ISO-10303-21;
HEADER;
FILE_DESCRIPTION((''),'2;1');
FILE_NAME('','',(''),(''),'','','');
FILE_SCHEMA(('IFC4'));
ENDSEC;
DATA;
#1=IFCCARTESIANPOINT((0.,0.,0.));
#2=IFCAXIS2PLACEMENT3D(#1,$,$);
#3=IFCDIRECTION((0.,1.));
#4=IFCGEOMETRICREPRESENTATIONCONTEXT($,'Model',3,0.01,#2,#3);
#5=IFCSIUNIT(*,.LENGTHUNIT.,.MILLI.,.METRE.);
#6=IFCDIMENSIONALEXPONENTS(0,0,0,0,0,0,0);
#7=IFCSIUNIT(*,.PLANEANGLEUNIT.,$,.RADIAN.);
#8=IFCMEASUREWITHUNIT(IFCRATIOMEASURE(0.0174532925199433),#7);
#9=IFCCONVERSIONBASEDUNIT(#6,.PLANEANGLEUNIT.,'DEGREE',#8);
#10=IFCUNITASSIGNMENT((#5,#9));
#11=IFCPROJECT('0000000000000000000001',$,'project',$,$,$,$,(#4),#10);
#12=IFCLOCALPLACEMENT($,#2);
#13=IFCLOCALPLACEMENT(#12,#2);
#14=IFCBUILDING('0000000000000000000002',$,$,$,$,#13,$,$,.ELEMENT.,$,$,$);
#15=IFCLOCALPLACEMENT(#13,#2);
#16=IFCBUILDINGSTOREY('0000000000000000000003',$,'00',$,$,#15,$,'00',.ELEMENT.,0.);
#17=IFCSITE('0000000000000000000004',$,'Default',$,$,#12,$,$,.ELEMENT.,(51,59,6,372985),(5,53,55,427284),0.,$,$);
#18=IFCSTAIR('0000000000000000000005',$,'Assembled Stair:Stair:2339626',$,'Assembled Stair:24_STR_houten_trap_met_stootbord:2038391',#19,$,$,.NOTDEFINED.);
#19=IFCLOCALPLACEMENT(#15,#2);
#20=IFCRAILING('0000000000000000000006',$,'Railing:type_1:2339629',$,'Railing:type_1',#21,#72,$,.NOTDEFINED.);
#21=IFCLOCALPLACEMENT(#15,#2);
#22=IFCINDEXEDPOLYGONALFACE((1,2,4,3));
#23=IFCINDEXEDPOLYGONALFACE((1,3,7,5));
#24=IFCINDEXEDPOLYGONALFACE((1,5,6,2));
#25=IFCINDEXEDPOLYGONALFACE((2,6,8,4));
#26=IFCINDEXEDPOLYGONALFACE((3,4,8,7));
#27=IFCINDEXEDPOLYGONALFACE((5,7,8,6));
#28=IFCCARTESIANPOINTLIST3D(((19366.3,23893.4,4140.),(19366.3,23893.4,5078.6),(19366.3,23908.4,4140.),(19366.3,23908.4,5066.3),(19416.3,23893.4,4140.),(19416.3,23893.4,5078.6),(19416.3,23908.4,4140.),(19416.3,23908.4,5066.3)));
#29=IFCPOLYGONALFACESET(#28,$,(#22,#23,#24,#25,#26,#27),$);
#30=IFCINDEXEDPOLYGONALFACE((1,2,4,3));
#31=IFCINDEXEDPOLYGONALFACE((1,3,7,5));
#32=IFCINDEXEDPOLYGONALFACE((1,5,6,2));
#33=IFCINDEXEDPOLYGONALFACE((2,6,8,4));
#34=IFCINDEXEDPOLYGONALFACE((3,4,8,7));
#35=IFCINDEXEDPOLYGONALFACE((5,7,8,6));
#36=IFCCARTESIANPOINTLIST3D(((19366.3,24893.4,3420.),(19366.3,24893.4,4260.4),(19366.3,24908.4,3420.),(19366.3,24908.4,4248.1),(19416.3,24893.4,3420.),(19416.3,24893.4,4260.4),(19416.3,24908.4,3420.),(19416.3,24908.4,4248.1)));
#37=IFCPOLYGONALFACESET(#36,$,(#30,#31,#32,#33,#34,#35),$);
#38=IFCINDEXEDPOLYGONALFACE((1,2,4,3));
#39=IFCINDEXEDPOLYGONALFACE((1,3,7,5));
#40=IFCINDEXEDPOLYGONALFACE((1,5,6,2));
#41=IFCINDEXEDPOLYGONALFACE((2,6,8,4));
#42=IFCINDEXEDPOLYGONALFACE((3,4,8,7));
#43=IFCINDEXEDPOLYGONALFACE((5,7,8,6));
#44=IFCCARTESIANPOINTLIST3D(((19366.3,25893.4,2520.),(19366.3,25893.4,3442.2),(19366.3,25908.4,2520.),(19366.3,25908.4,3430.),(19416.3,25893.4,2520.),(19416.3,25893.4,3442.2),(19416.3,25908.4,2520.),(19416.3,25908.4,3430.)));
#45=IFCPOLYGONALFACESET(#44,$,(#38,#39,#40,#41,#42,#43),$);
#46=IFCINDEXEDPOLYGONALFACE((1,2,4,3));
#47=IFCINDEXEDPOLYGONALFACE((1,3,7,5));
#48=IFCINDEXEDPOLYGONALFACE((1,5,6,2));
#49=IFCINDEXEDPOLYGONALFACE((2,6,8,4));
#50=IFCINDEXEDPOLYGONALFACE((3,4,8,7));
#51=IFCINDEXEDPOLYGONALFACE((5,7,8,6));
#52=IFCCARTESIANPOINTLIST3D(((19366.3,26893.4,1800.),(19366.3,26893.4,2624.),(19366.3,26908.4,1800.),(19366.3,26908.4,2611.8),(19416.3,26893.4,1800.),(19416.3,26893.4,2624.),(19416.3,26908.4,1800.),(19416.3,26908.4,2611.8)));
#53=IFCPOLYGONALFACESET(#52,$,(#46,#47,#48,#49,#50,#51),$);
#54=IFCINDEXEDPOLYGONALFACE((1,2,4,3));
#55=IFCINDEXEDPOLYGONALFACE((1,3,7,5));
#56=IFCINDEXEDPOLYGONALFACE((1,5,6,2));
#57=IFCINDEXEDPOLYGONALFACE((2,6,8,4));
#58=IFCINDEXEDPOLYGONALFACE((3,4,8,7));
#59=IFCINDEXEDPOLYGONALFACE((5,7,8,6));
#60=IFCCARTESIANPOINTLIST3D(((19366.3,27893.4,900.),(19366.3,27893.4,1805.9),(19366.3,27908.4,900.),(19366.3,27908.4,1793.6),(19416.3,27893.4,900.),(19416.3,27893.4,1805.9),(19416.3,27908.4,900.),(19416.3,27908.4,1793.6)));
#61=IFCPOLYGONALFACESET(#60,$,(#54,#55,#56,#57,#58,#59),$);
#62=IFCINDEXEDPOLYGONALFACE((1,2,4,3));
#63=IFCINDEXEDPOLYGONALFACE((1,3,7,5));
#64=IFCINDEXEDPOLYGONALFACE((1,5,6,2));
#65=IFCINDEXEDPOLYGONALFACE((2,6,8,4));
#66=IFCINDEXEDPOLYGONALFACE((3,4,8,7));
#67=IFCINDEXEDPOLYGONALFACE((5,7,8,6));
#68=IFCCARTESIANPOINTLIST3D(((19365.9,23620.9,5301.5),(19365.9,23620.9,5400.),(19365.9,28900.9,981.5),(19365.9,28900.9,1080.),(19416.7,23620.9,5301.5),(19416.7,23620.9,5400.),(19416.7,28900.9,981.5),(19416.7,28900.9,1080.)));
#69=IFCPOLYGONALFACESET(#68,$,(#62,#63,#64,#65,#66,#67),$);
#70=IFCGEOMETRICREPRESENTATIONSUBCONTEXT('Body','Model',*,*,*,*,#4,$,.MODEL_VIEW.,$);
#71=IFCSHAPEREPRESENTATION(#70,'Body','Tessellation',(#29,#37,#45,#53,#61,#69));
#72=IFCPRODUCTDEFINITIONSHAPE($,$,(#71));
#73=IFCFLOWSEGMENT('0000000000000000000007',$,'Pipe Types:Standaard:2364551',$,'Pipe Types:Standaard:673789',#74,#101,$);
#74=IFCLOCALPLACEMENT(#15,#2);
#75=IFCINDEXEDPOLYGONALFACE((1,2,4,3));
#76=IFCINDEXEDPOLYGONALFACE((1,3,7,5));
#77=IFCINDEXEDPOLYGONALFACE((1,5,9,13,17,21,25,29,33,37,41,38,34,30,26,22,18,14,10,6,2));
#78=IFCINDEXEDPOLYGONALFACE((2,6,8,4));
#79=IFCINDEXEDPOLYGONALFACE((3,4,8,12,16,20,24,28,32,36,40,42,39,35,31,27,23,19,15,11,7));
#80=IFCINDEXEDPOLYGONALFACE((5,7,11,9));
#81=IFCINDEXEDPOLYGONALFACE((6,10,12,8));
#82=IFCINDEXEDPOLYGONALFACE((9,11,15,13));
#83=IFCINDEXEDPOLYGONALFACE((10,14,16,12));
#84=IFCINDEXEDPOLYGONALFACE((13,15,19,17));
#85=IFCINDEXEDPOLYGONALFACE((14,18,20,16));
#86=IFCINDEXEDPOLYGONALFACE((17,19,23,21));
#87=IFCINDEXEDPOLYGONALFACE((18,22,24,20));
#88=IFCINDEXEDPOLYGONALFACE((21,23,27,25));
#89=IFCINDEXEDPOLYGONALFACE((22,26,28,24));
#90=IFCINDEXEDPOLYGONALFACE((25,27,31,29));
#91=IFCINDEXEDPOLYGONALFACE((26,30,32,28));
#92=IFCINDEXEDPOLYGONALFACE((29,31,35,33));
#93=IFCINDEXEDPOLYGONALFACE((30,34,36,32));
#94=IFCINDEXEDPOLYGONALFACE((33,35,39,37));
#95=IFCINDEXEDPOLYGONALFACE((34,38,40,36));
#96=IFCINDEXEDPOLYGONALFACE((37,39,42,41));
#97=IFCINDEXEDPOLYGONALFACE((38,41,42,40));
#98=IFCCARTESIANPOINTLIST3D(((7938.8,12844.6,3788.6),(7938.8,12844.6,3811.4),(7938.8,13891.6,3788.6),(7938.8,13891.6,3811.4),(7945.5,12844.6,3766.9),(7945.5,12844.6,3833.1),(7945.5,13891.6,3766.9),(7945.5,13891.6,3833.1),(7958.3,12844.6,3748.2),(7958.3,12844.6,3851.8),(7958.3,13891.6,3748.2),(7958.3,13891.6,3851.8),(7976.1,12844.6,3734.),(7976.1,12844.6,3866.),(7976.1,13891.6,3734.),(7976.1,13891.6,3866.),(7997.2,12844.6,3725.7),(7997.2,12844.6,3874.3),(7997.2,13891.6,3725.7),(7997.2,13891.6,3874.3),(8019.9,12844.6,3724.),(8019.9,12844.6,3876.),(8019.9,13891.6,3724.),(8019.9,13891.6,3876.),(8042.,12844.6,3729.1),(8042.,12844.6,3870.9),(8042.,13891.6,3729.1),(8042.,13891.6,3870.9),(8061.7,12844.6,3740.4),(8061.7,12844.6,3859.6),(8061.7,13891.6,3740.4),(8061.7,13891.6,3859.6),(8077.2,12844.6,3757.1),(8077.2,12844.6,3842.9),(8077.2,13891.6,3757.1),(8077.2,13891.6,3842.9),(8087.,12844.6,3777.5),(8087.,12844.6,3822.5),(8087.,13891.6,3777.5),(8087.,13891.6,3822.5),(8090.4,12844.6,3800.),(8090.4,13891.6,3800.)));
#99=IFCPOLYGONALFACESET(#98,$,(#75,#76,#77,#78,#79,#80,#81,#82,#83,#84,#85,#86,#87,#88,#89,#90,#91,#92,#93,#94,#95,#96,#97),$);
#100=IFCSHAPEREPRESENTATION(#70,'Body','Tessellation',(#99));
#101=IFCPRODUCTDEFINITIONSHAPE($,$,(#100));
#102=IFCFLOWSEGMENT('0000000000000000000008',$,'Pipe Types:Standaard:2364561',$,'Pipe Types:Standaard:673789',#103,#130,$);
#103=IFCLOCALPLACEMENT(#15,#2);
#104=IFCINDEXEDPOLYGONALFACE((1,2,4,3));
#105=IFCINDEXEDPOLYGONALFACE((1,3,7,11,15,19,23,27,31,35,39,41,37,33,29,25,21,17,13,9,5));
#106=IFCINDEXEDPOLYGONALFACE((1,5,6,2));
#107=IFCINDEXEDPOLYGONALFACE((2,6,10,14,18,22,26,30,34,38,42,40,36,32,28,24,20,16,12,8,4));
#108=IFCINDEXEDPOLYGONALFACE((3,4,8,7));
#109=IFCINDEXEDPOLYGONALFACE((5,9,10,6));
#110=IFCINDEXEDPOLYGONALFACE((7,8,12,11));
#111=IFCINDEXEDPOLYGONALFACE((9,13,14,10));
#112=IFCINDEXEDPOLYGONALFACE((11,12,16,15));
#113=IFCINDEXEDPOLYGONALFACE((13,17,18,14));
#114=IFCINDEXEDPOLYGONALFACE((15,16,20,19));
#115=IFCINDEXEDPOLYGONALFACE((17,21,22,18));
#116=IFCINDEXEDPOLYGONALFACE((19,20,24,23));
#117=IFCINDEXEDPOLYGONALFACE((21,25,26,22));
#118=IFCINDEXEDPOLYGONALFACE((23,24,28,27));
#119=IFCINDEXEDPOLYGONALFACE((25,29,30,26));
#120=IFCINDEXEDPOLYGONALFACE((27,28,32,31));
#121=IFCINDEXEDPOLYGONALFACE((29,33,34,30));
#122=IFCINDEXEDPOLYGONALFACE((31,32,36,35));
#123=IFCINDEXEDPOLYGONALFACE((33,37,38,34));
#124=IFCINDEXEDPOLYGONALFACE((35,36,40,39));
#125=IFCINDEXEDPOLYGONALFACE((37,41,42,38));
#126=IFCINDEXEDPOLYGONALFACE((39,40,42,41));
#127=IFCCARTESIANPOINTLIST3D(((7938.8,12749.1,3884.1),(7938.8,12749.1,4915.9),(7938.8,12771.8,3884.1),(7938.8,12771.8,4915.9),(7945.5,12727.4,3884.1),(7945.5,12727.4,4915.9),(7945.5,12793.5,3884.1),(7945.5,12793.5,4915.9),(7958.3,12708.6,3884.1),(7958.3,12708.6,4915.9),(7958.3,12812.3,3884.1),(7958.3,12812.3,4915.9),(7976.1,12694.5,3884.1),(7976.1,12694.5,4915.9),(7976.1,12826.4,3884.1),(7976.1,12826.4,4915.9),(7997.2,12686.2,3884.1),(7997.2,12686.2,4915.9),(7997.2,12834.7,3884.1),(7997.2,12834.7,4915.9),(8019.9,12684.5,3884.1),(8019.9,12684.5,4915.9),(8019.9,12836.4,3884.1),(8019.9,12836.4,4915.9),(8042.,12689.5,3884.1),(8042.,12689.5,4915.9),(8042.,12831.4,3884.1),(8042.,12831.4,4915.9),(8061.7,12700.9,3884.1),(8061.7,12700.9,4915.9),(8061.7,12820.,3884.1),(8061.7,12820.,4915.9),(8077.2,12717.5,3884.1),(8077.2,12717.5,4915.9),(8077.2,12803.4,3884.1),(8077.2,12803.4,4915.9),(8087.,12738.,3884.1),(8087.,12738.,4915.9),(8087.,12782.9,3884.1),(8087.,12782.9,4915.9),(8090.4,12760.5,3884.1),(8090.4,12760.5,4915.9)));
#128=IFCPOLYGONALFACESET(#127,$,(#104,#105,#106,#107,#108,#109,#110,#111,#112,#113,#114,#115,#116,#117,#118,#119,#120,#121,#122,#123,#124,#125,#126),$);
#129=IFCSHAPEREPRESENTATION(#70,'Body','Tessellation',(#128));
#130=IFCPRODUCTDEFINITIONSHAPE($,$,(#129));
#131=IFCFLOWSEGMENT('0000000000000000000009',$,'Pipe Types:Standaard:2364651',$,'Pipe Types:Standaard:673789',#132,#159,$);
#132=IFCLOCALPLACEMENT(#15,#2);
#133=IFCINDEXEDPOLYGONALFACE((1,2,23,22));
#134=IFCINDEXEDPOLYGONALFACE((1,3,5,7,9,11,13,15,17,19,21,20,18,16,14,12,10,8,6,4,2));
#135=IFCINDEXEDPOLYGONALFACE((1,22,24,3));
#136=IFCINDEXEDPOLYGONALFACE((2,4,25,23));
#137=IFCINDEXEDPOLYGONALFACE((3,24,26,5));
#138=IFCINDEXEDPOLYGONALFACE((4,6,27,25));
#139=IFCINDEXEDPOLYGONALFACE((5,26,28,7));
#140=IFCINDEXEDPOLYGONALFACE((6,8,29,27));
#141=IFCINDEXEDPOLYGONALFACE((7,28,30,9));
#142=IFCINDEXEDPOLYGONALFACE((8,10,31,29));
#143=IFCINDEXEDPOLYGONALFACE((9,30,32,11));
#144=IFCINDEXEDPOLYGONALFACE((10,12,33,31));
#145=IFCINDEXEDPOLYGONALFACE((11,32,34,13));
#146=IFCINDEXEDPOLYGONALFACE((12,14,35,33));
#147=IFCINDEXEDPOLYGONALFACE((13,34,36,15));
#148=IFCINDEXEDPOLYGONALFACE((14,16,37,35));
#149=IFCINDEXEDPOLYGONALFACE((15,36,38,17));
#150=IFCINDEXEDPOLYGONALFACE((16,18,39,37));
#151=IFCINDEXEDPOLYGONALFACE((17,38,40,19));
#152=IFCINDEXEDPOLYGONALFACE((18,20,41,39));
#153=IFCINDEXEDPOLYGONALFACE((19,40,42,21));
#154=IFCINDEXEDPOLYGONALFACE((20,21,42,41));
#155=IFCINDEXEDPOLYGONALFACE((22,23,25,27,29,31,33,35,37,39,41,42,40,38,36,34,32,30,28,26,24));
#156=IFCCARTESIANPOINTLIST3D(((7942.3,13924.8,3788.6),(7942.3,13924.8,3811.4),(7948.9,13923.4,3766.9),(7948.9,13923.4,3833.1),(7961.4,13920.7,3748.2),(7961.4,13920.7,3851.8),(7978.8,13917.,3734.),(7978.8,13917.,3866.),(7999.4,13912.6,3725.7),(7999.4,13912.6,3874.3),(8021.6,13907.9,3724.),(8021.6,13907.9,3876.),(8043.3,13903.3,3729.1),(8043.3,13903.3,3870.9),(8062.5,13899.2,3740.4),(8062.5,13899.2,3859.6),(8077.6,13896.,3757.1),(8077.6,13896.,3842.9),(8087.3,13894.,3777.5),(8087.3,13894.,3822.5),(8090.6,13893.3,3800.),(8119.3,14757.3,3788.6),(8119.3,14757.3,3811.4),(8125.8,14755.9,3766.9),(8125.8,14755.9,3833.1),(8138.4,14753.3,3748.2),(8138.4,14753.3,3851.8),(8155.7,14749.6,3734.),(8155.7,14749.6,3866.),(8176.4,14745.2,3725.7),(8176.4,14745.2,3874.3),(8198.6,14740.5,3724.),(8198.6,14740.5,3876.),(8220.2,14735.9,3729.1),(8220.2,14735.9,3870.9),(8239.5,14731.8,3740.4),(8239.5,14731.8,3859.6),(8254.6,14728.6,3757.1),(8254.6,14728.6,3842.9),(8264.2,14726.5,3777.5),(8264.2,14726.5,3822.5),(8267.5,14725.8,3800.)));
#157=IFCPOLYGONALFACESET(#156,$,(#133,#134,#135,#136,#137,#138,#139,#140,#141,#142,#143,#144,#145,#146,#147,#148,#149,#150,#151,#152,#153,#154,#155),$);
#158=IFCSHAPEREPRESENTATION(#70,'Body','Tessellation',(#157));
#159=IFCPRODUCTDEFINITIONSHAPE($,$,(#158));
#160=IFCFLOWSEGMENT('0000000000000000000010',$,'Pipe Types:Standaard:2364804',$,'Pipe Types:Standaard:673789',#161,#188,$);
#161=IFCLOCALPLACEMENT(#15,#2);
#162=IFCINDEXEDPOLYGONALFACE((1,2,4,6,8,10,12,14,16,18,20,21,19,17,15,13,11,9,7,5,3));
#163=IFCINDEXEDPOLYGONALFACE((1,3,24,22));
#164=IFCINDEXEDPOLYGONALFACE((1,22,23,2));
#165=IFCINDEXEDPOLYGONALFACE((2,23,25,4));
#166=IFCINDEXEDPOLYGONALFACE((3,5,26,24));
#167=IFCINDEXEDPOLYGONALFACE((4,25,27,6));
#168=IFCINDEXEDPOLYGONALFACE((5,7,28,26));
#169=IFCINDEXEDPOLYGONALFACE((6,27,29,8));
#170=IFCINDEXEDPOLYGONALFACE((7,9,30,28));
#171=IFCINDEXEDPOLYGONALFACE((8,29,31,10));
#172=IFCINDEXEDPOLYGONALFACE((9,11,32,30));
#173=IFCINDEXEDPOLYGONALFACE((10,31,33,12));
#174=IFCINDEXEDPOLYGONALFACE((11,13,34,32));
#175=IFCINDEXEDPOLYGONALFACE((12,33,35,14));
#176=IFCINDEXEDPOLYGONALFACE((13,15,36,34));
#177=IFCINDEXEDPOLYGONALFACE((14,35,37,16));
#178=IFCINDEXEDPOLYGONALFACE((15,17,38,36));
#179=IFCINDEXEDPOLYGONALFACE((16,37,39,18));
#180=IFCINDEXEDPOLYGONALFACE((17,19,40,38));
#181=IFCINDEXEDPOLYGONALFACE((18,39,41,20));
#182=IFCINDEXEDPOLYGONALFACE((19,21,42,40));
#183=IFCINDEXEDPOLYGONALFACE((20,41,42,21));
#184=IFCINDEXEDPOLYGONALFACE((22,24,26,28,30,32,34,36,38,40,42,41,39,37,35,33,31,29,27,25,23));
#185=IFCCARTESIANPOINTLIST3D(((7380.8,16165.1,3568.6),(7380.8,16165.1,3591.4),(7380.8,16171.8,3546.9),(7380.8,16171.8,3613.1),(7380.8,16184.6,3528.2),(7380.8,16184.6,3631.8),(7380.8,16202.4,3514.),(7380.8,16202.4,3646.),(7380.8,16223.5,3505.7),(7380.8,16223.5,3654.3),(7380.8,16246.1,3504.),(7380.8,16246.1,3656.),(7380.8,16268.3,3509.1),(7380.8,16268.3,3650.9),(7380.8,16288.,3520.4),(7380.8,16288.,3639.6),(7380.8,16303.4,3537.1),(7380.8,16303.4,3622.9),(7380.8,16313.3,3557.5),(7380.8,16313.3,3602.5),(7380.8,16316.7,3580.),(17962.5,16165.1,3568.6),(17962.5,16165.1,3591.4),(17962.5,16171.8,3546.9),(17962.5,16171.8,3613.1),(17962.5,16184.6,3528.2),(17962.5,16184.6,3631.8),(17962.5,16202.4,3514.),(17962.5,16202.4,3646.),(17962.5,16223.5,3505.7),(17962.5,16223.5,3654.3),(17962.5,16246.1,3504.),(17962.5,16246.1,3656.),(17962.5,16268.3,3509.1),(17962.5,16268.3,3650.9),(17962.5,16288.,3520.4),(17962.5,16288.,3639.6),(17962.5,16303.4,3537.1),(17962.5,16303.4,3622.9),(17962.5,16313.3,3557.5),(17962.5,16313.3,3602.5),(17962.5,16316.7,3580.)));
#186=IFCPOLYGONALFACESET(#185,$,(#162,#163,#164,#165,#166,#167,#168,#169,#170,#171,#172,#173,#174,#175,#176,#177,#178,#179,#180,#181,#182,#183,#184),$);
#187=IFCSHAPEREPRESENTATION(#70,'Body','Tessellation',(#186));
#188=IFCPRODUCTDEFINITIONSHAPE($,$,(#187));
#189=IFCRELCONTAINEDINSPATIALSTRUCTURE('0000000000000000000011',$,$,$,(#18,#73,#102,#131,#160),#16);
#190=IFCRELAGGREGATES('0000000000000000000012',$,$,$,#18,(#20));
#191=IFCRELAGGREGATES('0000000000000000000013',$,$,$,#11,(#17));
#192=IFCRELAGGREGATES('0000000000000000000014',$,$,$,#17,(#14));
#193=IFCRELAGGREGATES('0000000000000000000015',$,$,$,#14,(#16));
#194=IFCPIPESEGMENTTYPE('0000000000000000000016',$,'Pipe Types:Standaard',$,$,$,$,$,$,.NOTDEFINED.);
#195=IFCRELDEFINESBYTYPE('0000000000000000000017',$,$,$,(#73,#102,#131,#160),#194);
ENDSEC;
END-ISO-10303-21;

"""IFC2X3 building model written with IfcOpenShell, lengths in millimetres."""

from ifc_helpers import new_model, entity, si_unit, converted_unit, direction, frame, frame_2d, origin, origin_2d_with_axis, place, context, subcontext, project, spatial, polyline, circle, outline, extrude, type_object, element, aggregate, save


model = new_model("IFC2X3")

# Units and contexts
model_context = context("Model", 3, precision=0.01, world=origin(), true_north=direction((0.0, 1.0)))
body_context = subcontext(model_context, "Body", "Model", "MODEL_VIEW")
ifc_project = project(units=[si_unit("LENGTHUNIT", "METRE", prefix="MILLI"), converted_unit("PLANEANGLEUNIT", "DEGREE", entity("IfcRatioMeasure", 0.0174532925199433), si_unit("PLANEANGLEUNIT", "RADIAN"), dimensions=[0, 0, 0, 0, 0, 0, 0])], contexts=[model_context])

# Site, building, storey
site_placement = place(None, origin())
site = spatial("IfcSite", under=ifc_project, at=site_placement, Name="Default", CompositionType="ELEMENT", RefLatitude=(51, 59, 6, 372985), RefLongitude=(5, 53, 55, 427284), RefElevation=0.0)
building_placement = place(site_placement, origin())
building = spatial("IfcBuilding", under=site, at=building_placement, CompositionType="ELEMENT")
storey_placement = place(building_placement, origin())
storey = spatial("IfcBuildingStorey", under=building, at=storey_placement, Name="00", LongName="00", CompositionType="ELEMENT", Elevation=0.0)

# Stair, railing
stair_1_placement = place(storey_placement, origin())
stair_1 = element("IfcStair", 1, at=stair_1_placement, inside=storey, Name="Assembled Stair:Stair:2339626", ObjectType="Assembled Stair:24_STR_houten_trap_met_stootbord:2038391", ShapeType="NOTDEFINED")
railing_1_placement = place(stair_1_placement, origin())
railing_1 = element("IfcRailing", 2, at=railing_1_placement, Name="Railing:type_1:2339629", ObjectType="Railing:type_1", PredefinedType="NOTDEFINED", context=body_context, shape_type="SweptSolid", body=[
    extrude(outline(polyline([(-466.2, -7.5), (460.1, -7.5), (472.4, 7.5), (-466.2, 7.5), (-466.2, -7.5)])), frame((19366.3, 23900.9, 4606.2), z_axis=(1.0, 0.0, 0.0), x_axis=(0.0, 0.0, 1.0)), (0.0, 0.0, 1.0), 50.0),
    extrude(outline(polyline([(-417.1, -7.5), (411.0, -7.5), (423.3, 7.5), (-417.1, 7.5), (-417.1, -7.5)])), frame((19366.3, 24900.9, 3837.1), z_axis=(1.0, 0.0, 0.0), x_axis=(0.0, 0.0, 1.0)), (0.0, 0.0, 1.0), 50.0),
    extrude(outline(polyline([(-458.0, -7.5), (451.9, -7.5), (464.2, 7.5), (-458.0, 7.5), (-458.0, -7.5)])), frame((19366.3, 25900.9, 2978.0), z_axis=(1.0, 0.0, 0.0), x_axis=(0.0, 0.0, 1.0)), (0.0, 0.0, 1.0), 50.0),
    extrude(outline(polyline([(-409.0, -7.5), (402.8, -7.5), (415.1, 7.5), (-409.0, 7.5), (-409.0, -7.5)])), frame((19366.3, 26900.9, 2209.0), z_axis=(1.0, 0.0, 0.0), x_axis=(0.0, 0.0, 1.0)), (0.0, 0.0, 1.0), 50.0),
    extrude(outline(polyline([(-449.9, -7.5), (443.7, -7.5), (456.0, 7.5), (-449.9, 7.5), (-449.9, -7.5)])), frame((19366.3, 27900.9, 1349.9), z_axis=(1.0, 0.0, 0.0), x_axis=(0.0, 0.0, 1.0)), (0.0, 0.0, 1.0), 50.0),
    extrude(outline(polyline([(-3379.9, -38.1), (3442.2, -38.1), (3379.9, 38.1), (-3442.2, 38.1), (-3379.9, -38.1)])), frame((19365.9, 26260.9, 3190.8), z_axis=(1.0, 0.0, 0.0), x_axis=(0.0, -0.773957, 0.633238)), (0.0, 0.0, 1.0), 50.8),
])
aggregate(stair_1, [railing_1])

# Flow segments
pipe_segment_type = type_object("IfcPipeSegmentType", Name="Pipe Types:Standaard", PredefinedType="NOTDEFINED")
flow_segment_1_placement = place(storey_placement, origin())
element("IfcFlowSegment", 3, at=flow_segment_1_placement, inside=storey, type_object=pipe_segment_type, Name="Pipe Types:Standaard:2364551", ObjectType="Pipe Types:Standaard:673789", context=body_context, shape_type="SweptSolid", body=[
    extrude(circle(Radius=76.2, at=origin_2d_with_axis()), frame((8014.2, 12844.6, 3800.0), z_axis=(0.0, 1.0, 0.0), x_axis=(1.0, 0.0, 0.0)), (0.0, 0.0, 1.0), 1047.0),
])
flow_segment_2_placement = place(storey_placement, origin())
element("IfcFlowSegment", 4, at=flow_segment_2_placement, inside=storey, type_object=pipe_segment_type, Name="Pipe Types:Standaard:2364561", ObjectType="Pipe Types:Standaard:673789", context=body_context, shape_type="SweptSolid", body=[
    extrude(circle(Radius=76.2, at=origin_2d_with_axis()), frame((8014.2, 12760.5, 3884.1)), (0.0, 0.0, 1.0), 1031.7),
])
flow_segment_3_placement = place(storey_placement, origin())
element("IfcFlowSegment", 5, at=flow_segment_3_placement, inside=storey, type_object=pipe_segment_type, Name="Pipe Types:Standaard:2364651", ObjectType="Pipe Types:Standaard:673789", context=body_context, shape_type="SweptSolid", body=[
    extrude(circle(Radius=76.2, at=origin_2d_with_axis()), frame((8016.0, 13909.1, 3800.0), z_axis=(0.207912, 0.978148, 0.0), x_axis=(0.978148, -0.207912, 0.0)), (0.0, 0.0, 1.0), 851.2),
])
flow_segment_4_placement = place(storey_placement, origin())
element("IfcFlowSegment", 6, at=flow_segment_4_placement, inside=storey, type_object=pipe_segment_type, Name="Pipe Types:Standaard:2364804", ObjectType="Pipe Types:Standaard:673789", context=body_context, shape_type="SweptSolid", body=[
    extrude(circle(Radius=76.2, at=frame_2d((0.0, 0.0), x_axis=(1.0, 0.0))), frame((7380.8, 16240.5, 3580.0), z_axis=(1.0, 0.0, 0.0), x_axis=(0.0, 1.0, 0.0)), (0.0, 0.0, 1.0), 10581.7),
])

save(model, "model.ifc")
